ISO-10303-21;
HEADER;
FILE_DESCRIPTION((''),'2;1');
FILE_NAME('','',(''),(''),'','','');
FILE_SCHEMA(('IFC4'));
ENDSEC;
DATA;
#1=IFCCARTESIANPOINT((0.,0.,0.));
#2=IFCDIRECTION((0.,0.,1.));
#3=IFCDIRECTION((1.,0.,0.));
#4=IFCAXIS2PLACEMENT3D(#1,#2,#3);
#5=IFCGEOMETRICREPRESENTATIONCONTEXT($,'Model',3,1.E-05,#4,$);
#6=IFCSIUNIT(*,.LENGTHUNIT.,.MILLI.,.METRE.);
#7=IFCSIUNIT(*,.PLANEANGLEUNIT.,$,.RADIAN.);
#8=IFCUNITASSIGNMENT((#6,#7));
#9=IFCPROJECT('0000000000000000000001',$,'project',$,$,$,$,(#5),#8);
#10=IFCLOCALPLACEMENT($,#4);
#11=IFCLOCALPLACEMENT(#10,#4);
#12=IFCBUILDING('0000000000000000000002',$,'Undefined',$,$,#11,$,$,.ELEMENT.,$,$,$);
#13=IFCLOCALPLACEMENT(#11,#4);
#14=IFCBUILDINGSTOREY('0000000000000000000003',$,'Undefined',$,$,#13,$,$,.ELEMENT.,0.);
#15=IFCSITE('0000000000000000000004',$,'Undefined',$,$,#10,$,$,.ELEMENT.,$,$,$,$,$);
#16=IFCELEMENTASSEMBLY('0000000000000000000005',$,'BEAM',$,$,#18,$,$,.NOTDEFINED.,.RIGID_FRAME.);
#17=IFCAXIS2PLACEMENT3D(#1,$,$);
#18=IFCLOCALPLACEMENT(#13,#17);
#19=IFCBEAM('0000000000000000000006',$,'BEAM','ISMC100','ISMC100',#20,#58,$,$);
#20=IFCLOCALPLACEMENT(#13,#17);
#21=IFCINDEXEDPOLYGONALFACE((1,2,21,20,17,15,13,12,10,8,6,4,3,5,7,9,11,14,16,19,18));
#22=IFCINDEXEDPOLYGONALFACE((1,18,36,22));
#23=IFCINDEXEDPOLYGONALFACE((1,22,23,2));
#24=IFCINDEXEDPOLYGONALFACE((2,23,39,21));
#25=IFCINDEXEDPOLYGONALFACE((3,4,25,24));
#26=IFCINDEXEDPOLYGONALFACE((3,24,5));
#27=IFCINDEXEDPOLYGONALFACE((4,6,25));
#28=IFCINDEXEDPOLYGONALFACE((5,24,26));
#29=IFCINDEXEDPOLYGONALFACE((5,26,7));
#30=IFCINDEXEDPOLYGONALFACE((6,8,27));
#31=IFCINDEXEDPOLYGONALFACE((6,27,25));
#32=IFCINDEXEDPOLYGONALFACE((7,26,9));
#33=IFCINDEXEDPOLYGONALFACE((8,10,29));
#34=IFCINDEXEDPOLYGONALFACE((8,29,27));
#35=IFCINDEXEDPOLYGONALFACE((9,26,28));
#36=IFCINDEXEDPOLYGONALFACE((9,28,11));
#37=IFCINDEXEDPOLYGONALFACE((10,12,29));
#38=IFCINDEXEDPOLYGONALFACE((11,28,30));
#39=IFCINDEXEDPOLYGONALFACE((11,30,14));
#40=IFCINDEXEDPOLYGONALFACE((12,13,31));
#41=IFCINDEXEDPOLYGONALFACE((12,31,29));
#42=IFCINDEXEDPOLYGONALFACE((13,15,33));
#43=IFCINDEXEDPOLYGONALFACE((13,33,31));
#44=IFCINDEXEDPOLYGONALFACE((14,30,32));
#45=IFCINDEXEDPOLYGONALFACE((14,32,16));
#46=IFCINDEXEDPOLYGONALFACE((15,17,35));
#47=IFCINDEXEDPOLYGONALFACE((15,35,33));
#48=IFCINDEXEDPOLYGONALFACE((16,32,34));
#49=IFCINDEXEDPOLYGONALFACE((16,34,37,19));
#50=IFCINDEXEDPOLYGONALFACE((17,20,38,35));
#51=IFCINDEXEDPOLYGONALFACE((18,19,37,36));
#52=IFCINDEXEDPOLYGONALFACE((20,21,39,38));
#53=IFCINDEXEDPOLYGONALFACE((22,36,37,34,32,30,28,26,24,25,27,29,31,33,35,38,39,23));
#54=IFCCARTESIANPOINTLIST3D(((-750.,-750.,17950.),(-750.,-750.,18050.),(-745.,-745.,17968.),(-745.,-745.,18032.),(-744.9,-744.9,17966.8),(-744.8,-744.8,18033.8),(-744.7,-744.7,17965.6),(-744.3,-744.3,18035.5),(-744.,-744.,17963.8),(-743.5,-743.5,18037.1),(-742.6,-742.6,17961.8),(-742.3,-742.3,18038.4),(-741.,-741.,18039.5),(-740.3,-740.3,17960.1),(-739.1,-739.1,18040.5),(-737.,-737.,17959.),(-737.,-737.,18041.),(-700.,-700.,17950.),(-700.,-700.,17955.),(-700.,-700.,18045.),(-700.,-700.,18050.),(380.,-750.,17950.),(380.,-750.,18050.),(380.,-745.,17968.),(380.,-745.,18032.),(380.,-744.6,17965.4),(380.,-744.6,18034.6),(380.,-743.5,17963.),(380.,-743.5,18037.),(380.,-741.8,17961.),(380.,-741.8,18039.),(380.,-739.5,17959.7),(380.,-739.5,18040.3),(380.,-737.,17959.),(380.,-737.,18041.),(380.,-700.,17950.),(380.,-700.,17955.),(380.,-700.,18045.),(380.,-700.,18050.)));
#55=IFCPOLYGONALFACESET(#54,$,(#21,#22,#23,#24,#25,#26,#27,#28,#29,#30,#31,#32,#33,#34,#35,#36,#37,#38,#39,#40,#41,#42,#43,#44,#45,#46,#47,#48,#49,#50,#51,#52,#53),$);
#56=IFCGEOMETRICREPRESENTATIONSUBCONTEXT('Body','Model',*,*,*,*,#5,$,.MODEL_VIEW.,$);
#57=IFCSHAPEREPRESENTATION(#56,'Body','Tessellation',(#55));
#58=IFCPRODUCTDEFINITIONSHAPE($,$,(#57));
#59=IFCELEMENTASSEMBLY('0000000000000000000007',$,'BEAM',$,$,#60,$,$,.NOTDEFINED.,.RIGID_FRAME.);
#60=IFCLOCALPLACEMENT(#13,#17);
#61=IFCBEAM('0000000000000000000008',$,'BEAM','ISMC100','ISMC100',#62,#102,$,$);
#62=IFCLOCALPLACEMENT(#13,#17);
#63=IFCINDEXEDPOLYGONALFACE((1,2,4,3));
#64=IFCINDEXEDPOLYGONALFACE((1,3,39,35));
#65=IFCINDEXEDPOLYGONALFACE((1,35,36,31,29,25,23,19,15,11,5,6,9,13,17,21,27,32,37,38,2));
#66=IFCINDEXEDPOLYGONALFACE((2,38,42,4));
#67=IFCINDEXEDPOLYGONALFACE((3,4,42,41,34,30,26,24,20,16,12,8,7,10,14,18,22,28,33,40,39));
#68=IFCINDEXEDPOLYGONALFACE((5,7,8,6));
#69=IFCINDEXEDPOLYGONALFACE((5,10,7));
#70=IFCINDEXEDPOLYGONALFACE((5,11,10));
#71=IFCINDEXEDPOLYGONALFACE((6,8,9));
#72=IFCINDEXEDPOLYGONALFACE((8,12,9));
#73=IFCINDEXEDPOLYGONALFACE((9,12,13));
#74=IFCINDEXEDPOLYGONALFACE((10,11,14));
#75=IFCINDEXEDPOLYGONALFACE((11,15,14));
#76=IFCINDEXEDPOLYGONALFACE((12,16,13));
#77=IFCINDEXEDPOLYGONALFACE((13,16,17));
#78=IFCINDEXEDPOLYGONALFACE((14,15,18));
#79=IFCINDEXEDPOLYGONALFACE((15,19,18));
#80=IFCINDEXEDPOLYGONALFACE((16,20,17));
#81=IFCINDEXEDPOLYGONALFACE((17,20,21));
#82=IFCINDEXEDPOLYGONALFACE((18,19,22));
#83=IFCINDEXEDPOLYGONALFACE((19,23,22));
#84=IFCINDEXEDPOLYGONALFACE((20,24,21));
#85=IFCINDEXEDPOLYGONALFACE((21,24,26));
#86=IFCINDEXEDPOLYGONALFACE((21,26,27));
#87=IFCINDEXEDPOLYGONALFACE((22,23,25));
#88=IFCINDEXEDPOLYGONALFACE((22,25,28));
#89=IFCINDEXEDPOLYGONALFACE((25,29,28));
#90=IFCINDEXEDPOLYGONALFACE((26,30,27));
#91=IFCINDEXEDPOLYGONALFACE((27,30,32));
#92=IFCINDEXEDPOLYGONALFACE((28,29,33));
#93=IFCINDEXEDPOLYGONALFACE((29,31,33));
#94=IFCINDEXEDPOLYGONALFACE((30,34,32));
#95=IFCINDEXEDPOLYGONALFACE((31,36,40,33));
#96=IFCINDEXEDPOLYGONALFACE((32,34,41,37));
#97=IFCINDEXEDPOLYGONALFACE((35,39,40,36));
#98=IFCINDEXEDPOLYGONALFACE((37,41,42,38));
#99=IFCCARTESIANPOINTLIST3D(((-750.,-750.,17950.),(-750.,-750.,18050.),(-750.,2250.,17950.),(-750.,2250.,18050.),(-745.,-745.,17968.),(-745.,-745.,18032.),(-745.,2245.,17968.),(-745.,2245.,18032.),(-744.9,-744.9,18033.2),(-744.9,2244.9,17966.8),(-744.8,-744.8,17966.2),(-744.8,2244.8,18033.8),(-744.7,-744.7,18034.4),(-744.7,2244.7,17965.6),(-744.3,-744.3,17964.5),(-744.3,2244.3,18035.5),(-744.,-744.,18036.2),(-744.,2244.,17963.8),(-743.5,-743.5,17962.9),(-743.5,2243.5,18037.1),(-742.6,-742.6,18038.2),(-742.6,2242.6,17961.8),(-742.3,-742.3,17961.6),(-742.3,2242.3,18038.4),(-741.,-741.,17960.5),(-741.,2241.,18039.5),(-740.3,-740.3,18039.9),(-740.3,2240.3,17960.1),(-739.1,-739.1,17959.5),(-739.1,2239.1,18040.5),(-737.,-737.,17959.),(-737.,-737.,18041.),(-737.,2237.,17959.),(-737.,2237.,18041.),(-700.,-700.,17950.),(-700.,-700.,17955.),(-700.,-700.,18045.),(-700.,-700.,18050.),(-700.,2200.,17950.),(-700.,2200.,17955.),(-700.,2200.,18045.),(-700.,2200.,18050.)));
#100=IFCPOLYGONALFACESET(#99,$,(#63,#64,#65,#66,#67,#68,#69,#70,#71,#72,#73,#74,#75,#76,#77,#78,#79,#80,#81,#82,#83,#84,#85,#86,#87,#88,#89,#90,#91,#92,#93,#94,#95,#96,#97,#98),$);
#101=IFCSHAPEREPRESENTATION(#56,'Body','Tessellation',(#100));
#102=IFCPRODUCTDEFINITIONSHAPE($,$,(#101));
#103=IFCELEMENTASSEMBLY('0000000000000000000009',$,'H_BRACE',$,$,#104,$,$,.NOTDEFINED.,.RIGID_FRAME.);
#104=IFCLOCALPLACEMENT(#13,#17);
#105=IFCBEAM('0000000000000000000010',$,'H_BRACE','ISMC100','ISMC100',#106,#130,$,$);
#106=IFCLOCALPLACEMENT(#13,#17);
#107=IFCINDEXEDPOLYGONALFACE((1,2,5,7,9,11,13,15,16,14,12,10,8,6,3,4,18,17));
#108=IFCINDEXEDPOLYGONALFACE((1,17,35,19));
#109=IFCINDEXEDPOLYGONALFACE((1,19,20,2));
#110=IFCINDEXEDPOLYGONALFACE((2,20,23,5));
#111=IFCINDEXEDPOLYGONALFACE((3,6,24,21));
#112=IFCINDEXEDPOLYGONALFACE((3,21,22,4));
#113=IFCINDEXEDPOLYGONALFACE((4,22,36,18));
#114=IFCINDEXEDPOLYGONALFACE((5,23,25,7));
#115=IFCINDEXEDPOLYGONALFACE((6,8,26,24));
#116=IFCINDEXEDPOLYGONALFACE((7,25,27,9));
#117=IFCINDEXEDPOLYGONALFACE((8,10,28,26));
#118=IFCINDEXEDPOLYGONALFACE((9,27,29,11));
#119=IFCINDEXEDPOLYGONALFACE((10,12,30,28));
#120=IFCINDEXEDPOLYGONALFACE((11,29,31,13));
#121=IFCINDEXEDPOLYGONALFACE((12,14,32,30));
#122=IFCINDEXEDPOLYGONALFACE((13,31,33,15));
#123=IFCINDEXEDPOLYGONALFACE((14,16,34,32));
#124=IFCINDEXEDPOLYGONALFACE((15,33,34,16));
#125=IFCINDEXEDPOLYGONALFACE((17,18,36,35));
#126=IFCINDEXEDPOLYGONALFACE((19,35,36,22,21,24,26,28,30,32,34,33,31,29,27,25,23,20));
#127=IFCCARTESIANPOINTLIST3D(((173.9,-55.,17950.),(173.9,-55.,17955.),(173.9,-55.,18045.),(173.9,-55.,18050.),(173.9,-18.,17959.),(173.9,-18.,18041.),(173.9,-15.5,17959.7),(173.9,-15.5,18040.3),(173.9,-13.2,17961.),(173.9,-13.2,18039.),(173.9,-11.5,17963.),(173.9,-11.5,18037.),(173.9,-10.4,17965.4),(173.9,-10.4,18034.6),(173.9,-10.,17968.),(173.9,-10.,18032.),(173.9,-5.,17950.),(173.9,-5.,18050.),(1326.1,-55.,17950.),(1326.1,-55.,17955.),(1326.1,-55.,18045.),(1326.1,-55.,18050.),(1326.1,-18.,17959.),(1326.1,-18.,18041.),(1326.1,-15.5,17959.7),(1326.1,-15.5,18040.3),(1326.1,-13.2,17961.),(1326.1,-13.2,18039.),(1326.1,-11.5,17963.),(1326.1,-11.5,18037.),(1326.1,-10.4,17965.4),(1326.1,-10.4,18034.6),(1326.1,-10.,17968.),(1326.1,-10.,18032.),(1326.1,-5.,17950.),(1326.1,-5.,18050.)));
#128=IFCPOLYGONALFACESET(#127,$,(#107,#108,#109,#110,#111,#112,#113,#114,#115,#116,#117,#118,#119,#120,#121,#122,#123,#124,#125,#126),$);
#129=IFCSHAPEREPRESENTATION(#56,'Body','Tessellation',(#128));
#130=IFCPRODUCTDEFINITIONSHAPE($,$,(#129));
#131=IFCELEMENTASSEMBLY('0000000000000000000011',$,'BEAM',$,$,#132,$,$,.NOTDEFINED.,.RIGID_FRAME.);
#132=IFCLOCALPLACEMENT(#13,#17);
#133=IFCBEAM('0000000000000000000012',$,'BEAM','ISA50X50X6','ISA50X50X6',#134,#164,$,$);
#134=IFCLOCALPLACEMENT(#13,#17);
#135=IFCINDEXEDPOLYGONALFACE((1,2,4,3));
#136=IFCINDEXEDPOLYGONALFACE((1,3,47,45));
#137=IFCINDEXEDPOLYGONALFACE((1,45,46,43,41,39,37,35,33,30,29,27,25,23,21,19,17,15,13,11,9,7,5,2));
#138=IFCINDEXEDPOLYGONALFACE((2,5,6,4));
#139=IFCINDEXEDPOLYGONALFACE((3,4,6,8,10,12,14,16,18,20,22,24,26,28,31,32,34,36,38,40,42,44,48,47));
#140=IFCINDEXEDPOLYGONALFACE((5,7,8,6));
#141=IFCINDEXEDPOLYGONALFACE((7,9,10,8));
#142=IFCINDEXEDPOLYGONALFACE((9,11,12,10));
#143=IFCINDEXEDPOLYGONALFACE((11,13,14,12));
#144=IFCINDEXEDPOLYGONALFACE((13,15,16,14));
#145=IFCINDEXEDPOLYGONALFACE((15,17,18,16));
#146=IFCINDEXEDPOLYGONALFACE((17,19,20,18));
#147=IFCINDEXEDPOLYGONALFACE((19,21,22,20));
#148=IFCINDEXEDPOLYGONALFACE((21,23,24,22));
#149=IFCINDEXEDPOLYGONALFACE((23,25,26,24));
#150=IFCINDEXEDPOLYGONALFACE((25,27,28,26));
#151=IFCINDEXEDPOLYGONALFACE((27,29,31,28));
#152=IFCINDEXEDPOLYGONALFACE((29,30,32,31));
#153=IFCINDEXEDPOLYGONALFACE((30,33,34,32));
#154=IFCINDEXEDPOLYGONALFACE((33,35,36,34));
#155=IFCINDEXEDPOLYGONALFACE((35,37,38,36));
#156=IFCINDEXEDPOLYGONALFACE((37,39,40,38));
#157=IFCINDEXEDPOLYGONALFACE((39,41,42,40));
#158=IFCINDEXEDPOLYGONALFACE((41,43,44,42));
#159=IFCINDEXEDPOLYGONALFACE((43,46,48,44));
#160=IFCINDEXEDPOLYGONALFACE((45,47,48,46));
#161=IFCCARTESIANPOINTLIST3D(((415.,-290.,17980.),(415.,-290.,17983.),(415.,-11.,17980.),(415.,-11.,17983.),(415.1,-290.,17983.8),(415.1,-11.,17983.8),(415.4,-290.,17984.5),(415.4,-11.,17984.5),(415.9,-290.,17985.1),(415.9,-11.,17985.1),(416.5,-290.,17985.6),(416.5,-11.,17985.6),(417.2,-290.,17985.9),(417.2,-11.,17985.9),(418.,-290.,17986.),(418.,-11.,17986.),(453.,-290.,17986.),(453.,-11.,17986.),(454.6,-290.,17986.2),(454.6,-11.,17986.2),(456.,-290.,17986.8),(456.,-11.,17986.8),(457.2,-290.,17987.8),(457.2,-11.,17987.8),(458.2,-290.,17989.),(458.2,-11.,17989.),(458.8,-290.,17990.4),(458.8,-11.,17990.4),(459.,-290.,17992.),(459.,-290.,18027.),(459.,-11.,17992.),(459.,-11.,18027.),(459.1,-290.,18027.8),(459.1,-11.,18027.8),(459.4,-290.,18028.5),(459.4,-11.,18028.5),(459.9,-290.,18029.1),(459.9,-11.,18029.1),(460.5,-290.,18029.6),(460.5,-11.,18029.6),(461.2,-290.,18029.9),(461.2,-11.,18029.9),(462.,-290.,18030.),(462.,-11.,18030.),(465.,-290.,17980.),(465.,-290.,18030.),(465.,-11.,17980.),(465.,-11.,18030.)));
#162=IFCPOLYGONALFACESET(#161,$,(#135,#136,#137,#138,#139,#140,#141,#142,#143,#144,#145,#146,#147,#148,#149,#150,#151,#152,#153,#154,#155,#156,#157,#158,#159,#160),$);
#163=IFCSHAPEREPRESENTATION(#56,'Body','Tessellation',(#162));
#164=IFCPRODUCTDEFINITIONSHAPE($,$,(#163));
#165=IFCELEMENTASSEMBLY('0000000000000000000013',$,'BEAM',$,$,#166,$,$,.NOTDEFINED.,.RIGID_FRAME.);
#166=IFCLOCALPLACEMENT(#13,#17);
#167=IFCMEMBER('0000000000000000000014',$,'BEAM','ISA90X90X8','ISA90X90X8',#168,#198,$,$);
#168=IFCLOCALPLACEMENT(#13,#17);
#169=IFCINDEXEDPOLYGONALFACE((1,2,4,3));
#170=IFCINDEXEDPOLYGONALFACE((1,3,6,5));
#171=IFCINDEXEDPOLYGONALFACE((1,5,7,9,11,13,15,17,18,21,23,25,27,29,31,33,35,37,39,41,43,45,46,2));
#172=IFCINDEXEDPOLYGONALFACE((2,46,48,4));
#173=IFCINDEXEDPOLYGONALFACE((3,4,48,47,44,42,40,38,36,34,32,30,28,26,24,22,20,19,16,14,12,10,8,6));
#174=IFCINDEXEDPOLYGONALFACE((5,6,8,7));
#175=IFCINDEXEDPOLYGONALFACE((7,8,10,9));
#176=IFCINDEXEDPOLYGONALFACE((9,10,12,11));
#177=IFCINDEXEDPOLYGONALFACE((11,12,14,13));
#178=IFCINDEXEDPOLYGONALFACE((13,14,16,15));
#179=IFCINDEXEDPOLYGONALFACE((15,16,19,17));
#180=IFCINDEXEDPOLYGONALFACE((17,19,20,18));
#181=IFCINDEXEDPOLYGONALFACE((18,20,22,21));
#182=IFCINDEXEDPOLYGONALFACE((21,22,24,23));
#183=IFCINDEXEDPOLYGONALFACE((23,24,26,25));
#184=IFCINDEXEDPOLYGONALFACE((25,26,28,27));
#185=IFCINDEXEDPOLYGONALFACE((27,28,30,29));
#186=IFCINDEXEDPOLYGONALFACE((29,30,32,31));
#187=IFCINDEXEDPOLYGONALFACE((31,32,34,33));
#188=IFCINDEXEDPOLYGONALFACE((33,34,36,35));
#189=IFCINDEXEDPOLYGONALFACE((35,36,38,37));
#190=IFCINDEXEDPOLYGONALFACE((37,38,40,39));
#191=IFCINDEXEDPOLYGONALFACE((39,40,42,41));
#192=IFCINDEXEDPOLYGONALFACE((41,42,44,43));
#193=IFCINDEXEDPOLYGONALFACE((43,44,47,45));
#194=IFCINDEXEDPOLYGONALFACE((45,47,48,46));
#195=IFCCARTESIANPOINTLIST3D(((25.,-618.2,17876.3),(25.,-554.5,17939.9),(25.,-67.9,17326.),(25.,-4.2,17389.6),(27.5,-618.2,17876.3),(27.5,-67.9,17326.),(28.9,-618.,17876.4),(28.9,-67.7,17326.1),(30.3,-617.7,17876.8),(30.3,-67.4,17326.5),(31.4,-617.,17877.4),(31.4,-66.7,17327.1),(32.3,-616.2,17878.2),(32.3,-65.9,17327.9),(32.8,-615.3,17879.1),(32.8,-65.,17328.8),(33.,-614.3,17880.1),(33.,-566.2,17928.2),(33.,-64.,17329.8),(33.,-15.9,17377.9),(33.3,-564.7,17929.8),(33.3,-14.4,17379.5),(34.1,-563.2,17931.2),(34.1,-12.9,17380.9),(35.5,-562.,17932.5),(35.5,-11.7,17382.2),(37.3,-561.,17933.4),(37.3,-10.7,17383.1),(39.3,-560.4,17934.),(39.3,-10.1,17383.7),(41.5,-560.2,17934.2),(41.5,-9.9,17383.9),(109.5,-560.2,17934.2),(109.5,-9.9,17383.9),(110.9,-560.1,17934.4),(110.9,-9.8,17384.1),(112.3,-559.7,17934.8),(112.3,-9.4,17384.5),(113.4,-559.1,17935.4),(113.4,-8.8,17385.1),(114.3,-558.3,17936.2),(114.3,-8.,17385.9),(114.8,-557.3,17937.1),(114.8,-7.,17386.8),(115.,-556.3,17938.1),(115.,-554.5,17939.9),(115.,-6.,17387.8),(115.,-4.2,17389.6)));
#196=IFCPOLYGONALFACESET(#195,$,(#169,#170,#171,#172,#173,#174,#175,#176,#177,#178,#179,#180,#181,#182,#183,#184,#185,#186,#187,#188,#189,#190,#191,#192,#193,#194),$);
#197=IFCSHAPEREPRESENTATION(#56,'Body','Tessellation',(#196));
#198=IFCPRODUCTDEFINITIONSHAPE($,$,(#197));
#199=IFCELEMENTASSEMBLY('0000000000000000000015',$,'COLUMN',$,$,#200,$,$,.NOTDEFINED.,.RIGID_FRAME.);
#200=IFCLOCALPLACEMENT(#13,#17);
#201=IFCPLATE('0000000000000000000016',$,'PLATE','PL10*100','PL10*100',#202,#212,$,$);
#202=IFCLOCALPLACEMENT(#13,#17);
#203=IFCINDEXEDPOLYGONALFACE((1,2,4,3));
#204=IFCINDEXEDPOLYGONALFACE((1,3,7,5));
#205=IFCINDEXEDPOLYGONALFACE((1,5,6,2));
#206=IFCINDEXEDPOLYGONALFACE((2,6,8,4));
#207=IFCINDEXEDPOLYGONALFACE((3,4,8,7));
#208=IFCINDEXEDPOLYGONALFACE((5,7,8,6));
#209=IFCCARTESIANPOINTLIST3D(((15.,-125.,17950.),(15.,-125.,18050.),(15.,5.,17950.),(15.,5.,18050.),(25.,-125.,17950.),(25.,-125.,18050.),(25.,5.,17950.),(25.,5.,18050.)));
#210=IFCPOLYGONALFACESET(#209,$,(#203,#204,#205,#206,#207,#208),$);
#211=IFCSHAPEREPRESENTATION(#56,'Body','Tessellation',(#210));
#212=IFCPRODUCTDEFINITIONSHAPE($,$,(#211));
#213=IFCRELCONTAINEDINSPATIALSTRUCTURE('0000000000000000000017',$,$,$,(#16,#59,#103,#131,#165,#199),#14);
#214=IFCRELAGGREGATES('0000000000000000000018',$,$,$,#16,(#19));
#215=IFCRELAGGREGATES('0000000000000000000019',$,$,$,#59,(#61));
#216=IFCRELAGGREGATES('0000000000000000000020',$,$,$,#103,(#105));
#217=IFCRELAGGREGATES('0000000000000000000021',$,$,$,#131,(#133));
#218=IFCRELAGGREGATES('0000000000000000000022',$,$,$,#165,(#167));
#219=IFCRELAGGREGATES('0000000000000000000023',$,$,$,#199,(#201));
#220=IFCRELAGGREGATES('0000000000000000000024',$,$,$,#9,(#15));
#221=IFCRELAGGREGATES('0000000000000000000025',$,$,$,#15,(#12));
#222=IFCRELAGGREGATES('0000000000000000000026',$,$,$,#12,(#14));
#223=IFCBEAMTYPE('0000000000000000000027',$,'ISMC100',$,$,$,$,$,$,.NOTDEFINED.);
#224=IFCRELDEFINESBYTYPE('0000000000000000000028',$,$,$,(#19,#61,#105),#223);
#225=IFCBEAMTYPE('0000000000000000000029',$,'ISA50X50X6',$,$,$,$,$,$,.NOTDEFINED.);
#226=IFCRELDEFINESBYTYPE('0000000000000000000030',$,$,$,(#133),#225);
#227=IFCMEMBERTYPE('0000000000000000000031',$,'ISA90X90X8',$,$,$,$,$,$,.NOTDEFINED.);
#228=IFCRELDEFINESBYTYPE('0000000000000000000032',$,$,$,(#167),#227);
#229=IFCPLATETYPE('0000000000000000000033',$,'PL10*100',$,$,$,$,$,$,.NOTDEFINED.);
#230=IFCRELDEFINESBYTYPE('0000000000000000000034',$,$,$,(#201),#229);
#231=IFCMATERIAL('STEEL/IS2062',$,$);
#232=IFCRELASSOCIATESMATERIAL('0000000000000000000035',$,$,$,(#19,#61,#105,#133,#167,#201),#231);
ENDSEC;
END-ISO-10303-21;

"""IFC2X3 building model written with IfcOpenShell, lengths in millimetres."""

from ifc_helpers import new_model, si_unit, frame, origin_with_axes, origin_2d_with_axis, place, context, subcontext, project, spatial, polyline, l_section, u_section, outline, extrude, clip, halfspace, material, type_object, element, aggregate, save


model = new_model("IFC2X3")

# Units and contexts
model_context = context("Model", 3, precision=1e-05, world=origin_with_axes())
body_context = subcontext(model_context, "Body", "Model", "MODEL_VIEW")
ifc_project = project(units=[si_unit("LENGTHUNIT", "METRE", prefix="MILLI"), si_unit("PLANEANGLEUNIT", "RADIAN")], contexts=[model_context])

# Site, building, storey
site_placement = place(None, origin_with_axes())
site = spatial("IfcSite", under=ifc_project, at=site_placement, Name="Undefined", CompositionType="ELEMENT")
building_placement = place(site_placement, origin_with_axes())
building = spatial("IfcBuilding", under=site, at=building_placement, Name="Undefined", CompositionType="ELEMENT")
storey_placement = place(building_placement, origin_with_axes())
storey = spatial("IfcBuildingStorey", under=building, at=storey_placement, Name="Undefined", CompositionType="ELEMENT", Elevation=0.0)

# Shared definitions
ifc_material_1 = material(Name="STEEL/IS2062")

# Element assemblies, beams
assembly_1_placement = place(storey_placement, origin_with_axes())
assembly_1 = element("IfcElementAssembly", 1, at=assembly_1_placement, inside=storey, Name="BEAM", AssemblyPlace="NOTDEFINED", PredefinedType="RIGID_FRAME")
beam_type_1 = type_object("IfcBeamType", Name="ISMC100", PredefinedType="NOTDEFINED")
beam_1_placement = place(assembly_1_placement, frame((380.0, -725.0, 18000.0), z_axis=(0.0, 0.0, 1.0), x_axis=(-1.0, 0.0, 0.0)))
beam_1 = element("IfcBeam", 2, at=beam_1_placement, type_object=beam_type_1, material=ifc_material_1, Name="BEAM", Description="ISMC100", ObjectType="ISMC100", context=body_context, shape_type="Clipping", body=[
    clip(extrude(u_section(Depth=100.0, FlangeWidth=50.0, WebThickness=5.0, FlangeThickness=7.7, FilletRadius=9.0, FlangeSlope=0.10956, at=origin_2d_with_axis()), frame((1130.0, 0.0, 0.0), z_axis=(-1.0, 0.0, 0.0), x_axis=(0.0, -1.0, 0.0)), (0.0, 0.0, 1.0), 1130.0), halfspace(frame((1080.0, -25.0, -50.0), z_axis=(0.707107, -0.707107, 0.0), x_axis=(0.0, 0.0, 1.0)), False)),
])
aggregate(assembly_1, [beam_1])
assembly_2_placement = place(storey_placement, origin_with_axes())
assembly_2 = element("IfcElementAssembly", 3, at=assembly_2_placement, inside=storey, Name="BEAM", AssemblyPlace="NOTDEFINED", PredefinedType="RIGID_FRAME")
beam_2_placement = place(assembly_2_placement, frame((-725.0, -750.0, 18000.0), z_axis=(0.0, 0.0, 1.0), x_axis=(0.0, 1.0, 0.0)))
beam_2 = element("IfcBeam", 4, at=beam_2_placement, type_object=beam_type_1, material=ifc_material_1, Name="BEAM", Description="ISMC100", ObjectType="ISMC100", context=body_context, shape_type="Clipping", body=[
    clip(clip(extrude(u_section(Depth=100.0, FlangeWidth=50.0, WebThickness=5.0, FlangeThickness=7.7, FilletRadius=9.0, FlangeSlope=0.10956, at=origin_2d_with_axis()), frame((3000.0, 0.0, 0.0), z_axis=(-1.0, 0.0, 0.0), x_axis=(0.0, -1.0, 0.0)), (0.0, 0.0, 1.0), 3000.0), halfspace(frame((0.0, 25.0, -50.0), z_axis=(-0.707107, -0.707107, 0.0), x_axis=(0.0, 0.0, 1.0)), False)), halfspace(frame((2950.0, -25.0, -50.0), z_axis=(0.707107, -0.707107, 0.0), x_axis=(0.0, 0.0, 1.0)), False)),
])
aggregate(assembly_2, [beam_2])
assembly_3_placement = place(storey_placement, origin_with_axes())
assembly_3 = element("IfcElementAssembly", 5, at=assembly_3_placement, inside=storey, Name="H_BRACE", AssemblyPlace="NOTDEFINED", PredefinedType="RIGID_FRAME")
beam_3_placement = place(assembly_3_placement, frame((0.0, -30.0, 18000.0), z_axis=(0.0, 0.0, 1.0), x_axis=(1.0, 0.0, 0.0)))
beam_3 = element("IfcBeam", 6, at=beam_3_placement, type_object=beam_type_1, material=ifc_material_1, Name="H_BRACE", Description="ISMC100", ObjectType="ISMC100", context=body_context, shape_type="Clipping", body=[
    clip(clip(extrude(u_section(Depth=100.0, FlangeWidth=50.0, WebThickness=5.0, FlangeThickness=7.7, FilletRadius=9.0, FlangeSlope=0.10956, at=origin_2d_with_axis()), frame((1500.0, 0.0, 0.0), z_axis=(-1.0, 0.0, 0.0), x_axis=(0.0, -1.0, 0.0)), (0.0, 0.0, 1.0), 1500.0), halfspace(frame((1326.1, 25.0, 0.0), z_axis=(-1.0, 0.0, 0.0), x_axis=(0.0, 0.0, -1.0)), True)), halfspace(frame((173.9, 25.0, 0.0), z_axis=(1.0, 0.0, 0.0), x_axis=(0.0, 0.0, 1.0)), True)),
])
aggregate(assembly_3, [beam_3])
assembly_4_placement = place(storey_placement, origin_with_axes())
assembly_4 = element("IfcElementAssembly", 7, at=assembly_4_placement, inside=storey, Name="BEAM", AssemblyPlace="NOTDEFINED", PredefinedType="RIGID_FRAME")
beam_type_2 = type_object("IfcBeamType", Name="ISA50X50X6", PredefinedType="NOTDEFINED")
beam_4_placement = place(assembly_4_placement, frame((440.0, -11.0, 18005.0), z_axis=(0.0, 0.0, 1.0), x_axis=(0.0, -1.0, 0.0)))
beam_4 = element("IfcBeam", 8, at=beam_4_placement, type_object=beam_type_2, material=ifc_material_1, Name="BEAM", Description="ISA50X50X6", ObjectType="ISA50X50X6", context=body_context, shape_type="SweptSolid", body=[
    extrude(l_section(Depth=50.0, Width=50.0, Thickness=6.0, FilletRadius=6.0, EdgeRadius=3.0, at=origin_2d_with_axis()), frame((279.0, 0.0, 0.0), z_axis=(-1.0, 0.0, 0.0), x_axis=(0.0, -1.0, 0.0)), (0.0, 0.0, 1.0), 279.0),
])
aggregate(assembly_4, [beam_4])

# Element assembly, member
assembly_5_placement = place(storey_placement, origin_with_axes())
assembly_5 = element("IfcElementAssembly", 9, at=assembly_5_placement, inside=storey, Name="BEAM", AssemblyPlace="NOTDEFINED", PredefinedType="RIGID_FRAME")
member_type_1 = type_object("IfcMemberType", Name="ISA90X90X8", PredefinedType="NOTDEFINED")
member_1_placement = place(assembly_5_placement, frame((70.0, -586.4, 17908.1), z_axis=(1.0, 0.0, 0.0), x_axis=(0.0, 0.707107, -0.707107)))
member_1 = element("IfcMember", 10, at=member_1_placement, type_object=member_type_1, material=ifc_material_1, Name="BEAM", Description="ISA90X90X8", ObjectType="ISA90X90X8", context=body_context, shape_type="SweptSolid", body=[
    extrude(l_section(Depth=90.0, Width=90.0, Thickness=8.0, FilletRadius=8.5, EdgeRadius=5.5, at=origin_2d_with_axis()), frame((778.2, 0.0, 0.0), z_axis=(-1.0, 0.0, 0.0), x_axis=(0.0, -1.0, 0.0)), (0.0, 0.0, 1.0), 778.2),
])
aggregate(assembly_5, [member_1])

# Element assembly, plate
assembly_6_placement = place(storey_placement, origin_with_axes())
assembly_6 = element("IfcElementAssembly", 11, at=assembly_6_placement, inside=storey, Name="COLUMN", AssemblyPlace="NOTDEFINED", PredefinedType="RIGID_FRAME")
plate_type_1 = type_object("IfcPlateType", Name="PL10*100", PredefinedType="NOTDEFINED")
plate_1_placement = place(assembly_6_placement, frame((20.0, 5.0, 18050.0), z_axis=(-1.0, 0.0, 0.0), x_axis=(0.0, 0.0, -1.0)))
plate_1 = element("IfcPlate", 12, at=plate_1_placement, type_object=plate_type_1, material=ifc_material_1, Name="PLATE", Description="PL10*100", ObjectType="PL10*100", context=body_context, shape_type="SweptSolid", body=[
    extrude(outline(polyline([(0.0, 0.0), (100.0, 0.0), (100.0, 130.0), (0.0, 130.0), (0.0, 0.0)])), frame((0.0, 0.0, -5.0), z_axis=(0.0, 0.0, 1.0), x_axis=(1.0, 0.0, 0.0)), (0.0, 0.0, 1.0), 10.0),
])
aggregate(assembly_6, [plate_1])

save(model, "model.ifc")
